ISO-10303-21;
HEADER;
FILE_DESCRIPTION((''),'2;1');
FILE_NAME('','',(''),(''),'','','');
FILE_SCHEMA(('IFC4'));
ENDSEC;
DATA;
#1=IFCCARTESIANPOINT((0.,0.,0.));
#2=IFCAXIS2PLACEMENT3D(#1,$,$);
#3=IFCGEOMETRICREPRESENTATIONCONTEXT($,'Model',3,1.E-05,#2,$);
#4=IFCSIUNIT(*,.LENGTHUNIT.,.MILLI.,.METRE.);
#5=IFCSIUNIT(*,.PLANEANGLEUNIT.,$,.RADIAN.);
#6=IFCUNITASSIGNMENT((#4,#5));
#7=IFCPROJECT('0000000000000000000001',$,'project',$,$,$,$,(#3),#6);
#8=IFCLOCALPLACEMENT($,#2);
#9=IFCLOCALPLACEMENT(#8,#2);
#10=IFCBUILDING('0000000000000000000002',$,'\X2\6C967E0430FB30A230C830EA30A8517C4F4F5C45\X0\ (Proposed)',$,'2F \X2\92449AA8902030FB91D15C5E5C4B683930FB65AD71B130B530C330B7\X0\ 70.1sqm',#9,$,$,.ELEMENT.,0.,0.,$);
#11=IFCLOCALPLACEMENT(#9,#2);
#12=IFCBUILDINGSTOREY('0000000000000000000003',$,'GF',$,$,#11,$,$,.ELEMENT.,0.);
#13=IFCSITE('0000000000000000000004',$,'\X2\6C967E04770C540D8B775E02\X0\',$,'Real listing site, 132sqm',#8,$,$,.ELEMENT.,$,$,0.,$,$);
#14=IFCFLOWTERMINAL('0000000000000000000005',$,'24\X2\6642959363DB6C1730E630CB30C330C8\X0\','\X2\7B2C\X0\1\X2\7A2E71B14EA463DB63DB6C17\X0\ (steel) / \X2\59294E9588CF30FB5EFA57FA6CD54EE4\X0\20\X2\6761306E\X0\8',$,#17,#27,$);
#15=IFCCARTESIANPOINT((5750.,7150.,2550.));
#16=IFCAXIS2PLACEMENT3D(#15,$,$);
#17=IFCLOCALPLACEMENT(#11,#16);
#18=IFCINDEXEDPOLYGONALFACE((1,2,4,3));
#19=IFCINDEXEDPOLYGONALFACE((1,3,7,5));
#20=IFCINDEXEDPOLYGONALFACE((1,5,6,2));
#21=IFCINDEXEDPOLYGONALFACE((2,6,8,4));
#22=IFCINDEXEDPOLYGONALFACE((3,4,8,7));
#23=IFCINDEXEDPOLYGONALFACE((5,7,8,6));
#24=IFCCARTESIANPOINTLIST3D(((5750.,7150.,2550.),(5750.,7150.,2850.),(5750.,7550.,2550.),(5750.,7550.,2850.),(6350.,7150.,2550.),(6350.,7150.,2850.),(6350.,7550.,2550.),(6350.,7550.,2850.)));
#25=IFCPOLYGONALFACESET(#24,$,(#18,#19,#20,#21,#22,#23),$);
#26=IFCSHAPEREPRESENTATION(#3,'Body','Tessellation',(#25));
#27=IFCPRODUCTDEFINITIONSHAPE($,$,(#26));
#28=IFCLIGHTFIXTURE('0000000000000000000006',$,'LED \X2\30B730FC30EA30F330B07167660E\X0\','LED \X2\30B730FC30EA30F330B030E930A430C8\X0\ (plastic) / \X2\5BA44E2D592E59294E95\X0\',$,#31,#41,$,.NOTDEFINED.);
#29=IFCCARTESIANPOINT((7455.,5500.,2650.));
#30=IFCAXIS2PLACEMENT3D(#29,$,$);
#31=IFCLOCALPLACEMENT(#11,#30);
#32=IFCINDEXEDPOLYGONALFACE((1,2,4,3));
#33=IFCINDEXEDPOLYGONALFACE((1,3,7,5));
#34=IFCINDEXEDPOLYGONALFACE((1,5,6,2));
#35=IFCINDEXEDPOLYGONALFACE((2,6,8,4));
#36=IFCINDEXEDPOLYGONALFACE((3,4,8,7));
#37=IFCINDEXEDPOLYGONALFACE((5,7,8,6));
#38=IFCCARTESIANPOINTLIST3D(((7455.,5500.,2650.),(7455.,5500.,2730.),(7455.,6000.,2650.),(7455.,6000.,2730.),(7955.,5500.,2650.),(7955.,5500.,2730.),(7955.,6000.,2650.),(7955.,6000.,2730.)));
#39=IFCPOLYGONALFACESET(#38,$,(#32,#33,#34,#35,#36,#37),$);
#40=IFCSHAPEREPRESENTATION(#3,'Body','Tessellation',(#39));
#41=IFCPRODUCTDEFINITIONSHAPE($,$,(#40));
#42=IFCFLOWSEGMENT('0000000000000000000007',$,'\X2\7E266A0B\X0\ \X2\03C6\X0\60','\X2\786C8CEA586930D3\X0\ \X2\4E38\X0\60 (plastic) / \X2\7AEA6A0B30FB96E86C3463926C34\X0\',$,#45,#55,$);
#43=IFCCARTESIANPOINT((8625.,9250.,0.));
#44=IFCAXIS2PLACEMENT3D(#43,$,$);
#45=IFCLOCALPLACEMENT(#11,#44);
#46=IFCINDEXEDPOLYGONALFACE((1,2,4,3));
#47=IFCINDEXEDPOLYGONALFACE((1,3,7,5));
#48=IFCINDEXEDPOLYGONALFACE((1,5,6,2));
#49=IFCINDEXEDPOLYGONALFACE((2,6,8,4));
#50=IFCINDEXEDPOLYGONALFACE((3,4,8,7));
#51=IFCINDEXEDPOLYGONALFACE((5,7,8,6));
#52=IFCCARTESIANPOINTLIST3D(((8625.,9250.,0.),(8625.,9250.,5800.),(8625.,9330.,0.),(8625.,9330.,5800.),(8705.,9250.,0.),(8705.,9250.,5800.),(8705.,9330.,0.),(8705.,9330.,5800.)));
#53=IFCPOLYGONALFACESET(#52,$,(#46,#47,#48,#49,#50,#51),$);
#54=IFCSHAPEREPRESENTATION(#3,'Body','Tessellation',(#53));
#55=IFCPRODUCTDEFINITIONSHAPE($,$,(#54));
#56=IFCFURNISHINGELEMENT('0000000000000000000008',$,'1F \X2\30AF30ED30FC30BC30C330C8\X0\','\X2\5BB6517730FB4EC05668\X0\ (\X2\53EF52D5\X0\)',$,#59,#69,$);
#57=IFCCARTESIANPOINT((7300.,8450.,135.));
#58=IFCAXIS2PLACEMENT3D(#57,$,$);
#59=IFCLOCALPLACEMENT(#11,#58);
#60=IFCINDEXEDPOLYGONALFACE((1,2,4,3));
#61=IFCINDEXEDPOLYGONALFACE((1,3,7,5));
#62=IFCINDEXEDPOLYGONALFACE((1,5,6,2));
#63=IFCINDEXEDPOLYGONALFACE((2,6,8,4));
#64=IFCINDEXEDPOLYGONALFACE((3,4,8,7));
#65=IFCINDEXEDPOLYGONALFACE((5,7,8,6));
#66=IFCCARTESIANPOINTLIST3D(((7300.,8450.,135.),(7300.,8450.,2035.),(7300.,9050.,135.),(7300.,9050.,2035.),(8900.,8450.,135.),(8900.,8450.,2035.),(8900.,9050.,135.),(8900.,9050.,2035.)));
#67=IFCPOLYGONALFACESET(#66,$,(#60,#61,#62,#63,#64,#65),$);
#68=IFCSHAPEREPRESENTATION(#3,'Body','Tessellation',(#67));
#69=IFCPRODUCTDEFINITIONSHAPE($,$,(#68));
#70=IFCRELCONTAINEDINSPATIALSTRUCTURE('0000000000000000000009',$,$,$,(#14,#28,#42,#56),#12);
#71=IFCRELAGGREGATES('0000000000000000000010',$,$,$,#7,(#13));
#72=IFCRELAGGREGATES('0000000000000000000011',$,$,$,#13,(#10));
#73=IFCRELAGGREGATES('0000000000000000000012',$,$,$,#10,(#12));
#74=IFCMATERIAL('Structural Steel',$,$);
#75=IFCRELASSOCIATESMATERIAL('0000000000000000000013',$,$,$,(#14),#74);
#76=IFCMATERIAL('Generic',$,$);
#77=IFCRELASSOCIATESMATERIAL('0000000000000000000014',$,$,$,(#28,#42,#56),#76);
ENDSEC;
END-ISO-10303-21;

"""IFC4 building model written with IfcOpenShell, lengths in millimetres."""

from ifc_helpers import new_model, si_unit, frame, frame_2d, origin, place, context, project, spatial, rectangle, extrude, material, element, save


model = new_model("IFC4")

# Units and contexts
model_context = context("Model", 3, precision=1e-05, world=origin())
ifc_project = project(units=[si_unit("LENGTHUNIT", "METRE", prefix="MILLI"), si_unit("PLANEANGLEUNIT", "RADIAN")], contexts=[model_context])

# Site, building, storey
site_placement = place(None, origin())
site = spatial("IfcSite", under=ifc_project, at=site_placement, Name="沖縄県名護市", ObjectType="Real listing site, 132sqm", CompositionType="ELEMENT", RefElevation=0.0)
building_placement = place(site_placement, origin())
building = spatial("IfcBuilding", under=site, at=building_placement, Name="沖縄・アトリエ兼住居 (Proposed)", ObjectType="2F 鉄骨造・金属屋根・断熱サッシ 70.1sqm", CompositionType="ELEMENT", ElevationOfRefHeight=0.0, ElevationOfTerrain=0.0)
storey_placement = place(building_placement, origin())
storey = spatial("IfcBuildingStorey", under=building, at=storey_placement, Name="GF", CompositionType="ELEMENT", Elevation=0.0)

# Shared definitions
ifc_material_1 = material(Name="Generic")

# Flow terminal
ifc_material_2 = material(Name="Structural Steel")
flow_terminal_placement = place(storey_placement, frame((5750.0, 7150.0, 2550.0)))
element("IfcFlowTerminal", 1, at=flow_terminal_placement, inside=storey, material=ifc_material_2, Name="24時間換気ユニット", Description="第1種熱交換換気 (steel) / 天井裏・建基法令20条の8", context=model_context, shape_type="SweptSolid", body=[
    extrude(rectangle(XDim=600.0, YDim=400.0, at=frame_2d((300.0, 200.0))), frame((5750.0, 7150.0, 2550.0)), (0.0, 0.0, 1.0), 300.0),
])

# Light fixture
light_fixture_placement = place(storey_placement, frame((7455.0, 5500.0, 2650.0)))
element("IfcLightFixture", 2, at=light_fixture_placement, inside=storey, material=ifc_material_1, Name="LED シーリング照明", Description="LED シーリングライト (plastic) / 室中央天井", PredefinedType="NOTDEFINED", context=model_context, shape_type="SweptSolid", body=[
    extrude(rectangle(XDim=500.0, YDim=500.0, at=frame_2d((250.0, 250.0))), frame((7455.0, 5500.0, 2650.0)), (0.0, 0.0, 1.0), 80.0),
])

# Flow segment
flow_segment_placement = place(storey_placement, frame((8625.0, 9250.0, 0.0)))
element("IfcFlowSegment", 3, at=flow_segment_placement, inside=storey, material=ifc_material_1, Name="縦樋 φ60", Description="硬質塩ビ 丸60 (plastic) / 竪樋・雨水排水", context=model_context, shape_type="SweptSolid", body=[
    extrude(rectangle(XDim=80.0, YDim=80.0, at=frame_2d((40.0, 40.0))), frame((8625.0, 9250.0, 0.0)), (0.0, 0.0, 1.0), 5800.0),
])

# Furnishing element
furnishing_placement = place(storey_placement, frame((7300.0, 8450.0, 135.0)))
element("IfcFurnishingElement", 4, at=furnishing_placement, inside=storey, material=ifc_material_1, Name="1F クローゼット", Description="家具・什器 (可動)", context=model_context, shape_type="SweptSolid", body=[
    extrude(rectangle(XDim=1600.0, YDim=600.0, at=frame_2d((800.0, 300.0))), frame((7300.0, 8450.0, 135.0)), (0.0, 0.0, 1.0), 1900.0),
])

save(model, "model.ifc")
